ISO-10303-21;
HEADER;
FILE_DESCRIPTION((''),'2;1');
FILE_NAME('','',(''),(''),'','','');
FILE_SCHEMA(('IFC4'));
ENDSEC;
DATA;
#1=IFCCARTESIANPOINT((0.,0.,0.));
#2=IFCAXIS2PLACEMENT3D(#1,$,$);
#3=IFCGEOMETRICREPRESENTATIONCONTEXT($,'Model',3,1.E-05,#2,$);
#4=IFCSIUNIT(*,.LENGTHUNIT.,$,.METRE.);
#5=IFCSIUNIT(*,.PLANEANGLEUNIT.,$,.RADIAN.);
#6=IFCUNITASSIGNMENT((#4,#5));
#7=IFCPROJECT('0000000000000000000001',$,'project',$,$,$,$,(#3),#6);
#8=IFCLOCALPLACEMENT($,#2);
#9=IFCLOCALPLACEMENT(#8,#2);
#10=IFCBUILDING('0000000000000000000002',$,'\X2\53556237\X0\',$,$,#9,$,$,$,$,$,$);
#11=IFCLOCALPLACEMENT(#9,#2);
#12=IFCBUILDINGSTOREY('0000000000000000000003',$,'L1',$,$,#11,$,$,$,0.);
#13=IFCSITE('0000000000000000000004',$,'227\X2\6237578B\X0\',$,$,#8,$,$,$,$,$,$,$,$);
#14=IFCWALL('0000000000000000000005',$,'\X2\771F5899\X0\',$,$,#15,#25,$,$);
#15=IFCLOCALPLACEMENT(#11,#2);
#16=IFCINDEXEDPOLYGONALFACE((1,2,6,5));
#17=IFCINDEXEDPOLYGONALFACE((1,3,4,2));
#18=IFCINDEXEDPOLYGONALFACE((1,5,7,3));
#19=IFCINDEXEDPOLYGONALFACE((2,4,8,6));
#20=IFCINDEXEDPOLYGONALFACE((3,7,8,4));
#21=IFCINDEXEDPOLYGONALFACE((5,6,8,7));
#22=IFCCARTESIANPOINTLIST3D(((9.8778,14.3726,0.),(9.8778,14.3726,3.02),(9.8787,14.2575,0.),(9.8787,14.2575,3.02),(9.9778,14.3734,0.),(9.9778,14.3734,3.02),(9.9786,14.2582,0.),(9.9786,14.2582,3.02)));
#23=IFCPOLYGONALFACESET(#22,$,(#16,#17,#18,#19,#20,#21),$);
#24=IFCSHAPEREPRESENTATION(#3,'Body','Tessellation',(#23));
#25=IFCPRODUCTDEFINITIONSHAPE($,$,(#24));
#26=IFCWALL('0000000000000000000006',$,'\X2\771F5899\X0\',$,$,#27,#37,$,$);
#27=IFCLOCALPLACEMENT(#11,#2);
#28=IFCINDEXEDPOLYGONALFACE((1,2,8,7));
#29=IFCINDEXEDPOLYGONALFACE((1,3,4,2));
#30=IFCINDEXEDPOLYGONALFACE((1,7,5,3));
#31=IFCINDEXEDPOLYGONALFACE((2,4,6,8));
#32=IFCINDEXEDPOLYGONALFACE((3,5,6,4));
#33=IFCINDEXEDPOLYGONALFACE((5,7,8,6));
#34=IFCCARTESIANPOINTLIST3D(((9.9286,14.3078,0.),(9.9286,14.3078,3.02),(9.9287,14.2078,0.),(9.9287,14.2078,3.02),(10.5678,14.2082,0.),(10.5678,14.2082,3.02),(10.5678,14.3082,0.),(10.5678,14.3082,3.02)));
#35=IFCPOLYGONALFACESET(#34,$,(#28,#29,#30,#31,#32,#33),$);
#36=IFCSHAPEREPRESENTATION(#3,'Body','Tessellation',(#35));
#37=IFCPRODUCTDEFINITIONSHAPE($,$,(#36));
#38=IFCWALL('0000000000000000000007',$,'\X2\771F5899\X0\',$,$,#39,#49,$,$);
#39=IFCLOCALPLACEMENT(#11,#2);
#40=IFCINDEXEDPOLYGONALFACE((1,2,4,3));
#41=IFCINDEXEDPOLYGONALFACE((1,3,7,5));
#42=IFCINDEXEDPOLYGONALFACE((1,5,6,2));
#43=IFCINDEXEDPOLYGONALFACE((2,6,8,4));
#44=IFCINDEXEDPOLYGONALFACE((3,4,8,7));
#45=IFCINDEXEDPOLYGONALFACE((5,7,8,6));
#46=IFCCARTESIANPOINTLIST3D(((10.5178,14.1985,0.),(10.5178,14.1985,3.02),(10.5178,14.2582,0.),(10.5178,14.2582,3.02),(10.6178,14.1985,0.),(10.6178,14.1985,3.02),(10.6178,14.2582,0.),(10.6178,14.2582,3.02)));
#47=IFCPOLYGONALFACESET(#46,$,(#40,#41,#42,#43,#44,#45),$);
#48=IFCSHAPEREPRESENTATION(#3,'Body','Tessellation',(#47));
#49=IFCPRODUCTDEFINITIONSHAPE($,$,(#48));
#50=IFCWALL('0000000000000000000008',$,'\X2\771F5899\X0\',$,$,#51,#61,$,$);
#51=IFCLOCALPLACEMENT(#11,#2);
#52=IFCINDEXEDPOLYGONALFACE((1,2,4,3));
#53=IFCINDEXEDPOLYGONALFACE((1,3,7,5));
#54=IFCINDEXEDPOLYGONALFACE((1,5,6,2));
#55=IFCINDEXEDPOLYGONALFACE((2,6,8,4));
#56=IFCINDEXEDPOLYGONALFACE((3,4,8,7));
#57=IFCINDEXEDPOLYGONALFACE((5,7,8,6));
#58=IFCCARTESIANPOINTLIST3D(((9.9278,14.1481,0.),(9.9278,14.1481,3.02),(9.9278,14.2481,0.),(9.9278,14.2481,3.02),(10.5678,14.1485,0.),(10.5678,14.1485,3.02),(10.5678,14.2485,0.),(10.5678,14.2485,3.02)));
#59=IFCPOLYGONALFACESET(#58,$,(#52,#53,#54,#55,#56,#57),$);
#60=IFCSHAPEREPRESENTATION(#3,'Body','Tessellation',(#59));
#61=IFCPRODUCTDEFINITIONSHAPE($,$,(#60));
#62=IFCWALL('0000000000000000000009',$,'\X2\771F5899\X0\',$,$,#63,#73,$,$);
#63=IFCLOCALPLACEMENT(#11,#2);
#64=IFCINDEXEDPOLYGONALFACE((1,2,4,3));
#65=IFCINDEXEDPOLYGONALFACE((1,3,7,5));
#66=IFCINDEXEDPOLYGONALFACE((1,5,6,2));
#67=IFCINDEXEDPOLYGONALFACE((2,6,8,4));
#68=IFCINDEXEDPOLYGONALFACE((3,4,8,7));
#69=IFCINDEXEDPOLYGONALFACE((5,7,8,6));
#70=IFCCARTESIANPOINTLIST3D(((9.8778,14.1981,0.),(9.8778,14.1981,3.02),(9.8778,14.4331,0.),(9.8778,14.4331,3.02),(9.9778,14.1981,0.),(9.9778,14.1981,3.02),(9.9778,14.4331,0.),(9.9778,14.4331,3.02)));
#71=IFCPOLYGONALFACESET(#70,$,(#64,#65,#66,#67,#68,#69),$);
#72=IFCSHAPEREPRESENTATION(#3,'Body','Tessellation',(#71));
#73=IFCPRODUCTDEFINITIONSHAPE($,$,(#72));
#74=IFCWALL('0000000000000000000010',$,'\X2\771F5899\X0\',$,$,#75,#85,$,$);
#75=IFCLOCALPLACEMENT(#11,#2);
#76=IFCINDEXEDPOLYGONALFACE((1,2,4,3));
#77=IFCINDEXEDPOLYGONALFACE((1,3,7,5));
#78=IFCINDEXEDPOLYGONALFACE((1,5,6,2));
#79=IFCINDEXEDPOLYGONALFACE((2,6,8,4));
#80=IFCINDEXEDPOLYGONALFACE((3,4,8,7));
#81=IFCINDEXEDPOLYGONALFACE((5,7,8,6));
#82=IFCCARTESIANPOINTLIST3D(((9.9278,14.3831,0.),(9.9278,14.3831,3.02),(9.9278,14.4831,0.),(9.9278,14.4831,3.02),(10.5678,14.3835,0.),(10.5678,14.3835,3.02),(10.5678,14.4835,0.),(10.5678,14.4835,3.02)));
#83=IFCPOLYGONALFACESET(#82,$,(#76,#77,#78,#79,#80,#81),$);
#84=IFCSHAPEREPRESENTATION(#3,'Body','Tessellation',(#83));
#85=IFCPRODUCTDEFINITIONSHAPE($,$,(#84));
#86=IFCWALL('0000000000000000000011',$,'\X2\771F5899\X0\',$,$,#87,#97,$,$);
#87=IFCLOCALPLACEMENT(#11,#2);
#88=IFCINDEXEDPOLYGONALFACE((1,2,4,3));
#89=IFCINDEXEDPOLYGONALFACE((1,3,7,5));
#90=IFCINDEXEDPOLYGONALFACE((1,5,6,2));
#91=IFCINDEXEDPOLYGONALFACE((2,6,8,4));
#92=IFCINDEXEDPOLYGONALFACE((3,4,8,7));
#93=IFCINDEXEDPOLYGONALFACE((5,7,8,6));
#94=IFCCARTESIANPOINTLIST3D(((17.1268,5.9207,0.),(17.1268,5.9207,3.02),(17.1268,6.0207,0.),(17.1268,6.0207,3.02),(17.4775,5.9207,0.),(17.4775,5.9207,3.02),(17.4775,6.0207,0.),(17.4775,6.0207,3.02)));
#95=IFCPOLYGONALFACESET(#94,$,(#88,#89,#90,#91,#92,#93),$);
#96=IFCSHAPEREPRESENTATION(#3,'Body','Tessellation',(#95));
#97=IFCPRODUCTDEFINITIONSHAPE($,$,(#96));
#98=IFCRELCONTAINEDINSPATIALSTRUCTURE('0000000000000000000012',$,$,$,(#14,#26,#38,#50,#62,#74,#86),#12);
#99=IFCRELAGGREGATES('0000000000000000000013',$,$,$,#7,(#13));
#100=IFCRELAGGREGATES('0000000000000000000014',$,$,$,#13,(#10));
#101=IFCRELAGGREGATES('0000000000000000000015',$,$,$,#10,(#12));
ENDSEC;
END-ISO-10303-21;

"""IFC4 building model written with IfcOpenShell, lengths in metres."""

from ifc_helpers import new_model, si_unit, origin, place, context, project, spatial, polyline, outline, extrude, element, save


model = new_model("IFC4")

# Units and contexts
model_context = context("Model", 3, precision=1e-05, world=origin())
ifc_project = project(units=[si_unit("LENGTHUNIT", "METRE"), si_unit("PLANEANGLEUNIT", "RADIAN")], contexts=[model_context])

# Site, building, storey
site_placement = place(None, origin())
site = spatial("IfcSite", under=ifc_project, at=site_placement, Name="227户型")
building_placement = place(site_placement, origin())
building = spatial("IfcBuilding", under=site, at=building_placement, Name="单户")
storey_placement = place(building_placement, origin())
storey = spatial("IfcBuildingStorey", under=building, at=storey_placement, Name="L1", Elevation=0.0)

# Walls
wall_1_placement = place(storey_placement, origin())
element("IfcWall", 1, at=wall_1_placement, inside=storey, Name="真墙", context=model_context, shape_type="SweptSolid", body=[
    extrude(outline(polyline([(9.9778, 14.3734), (9.9786, 14.2582), (9.8787, 14.2575), (9.8778, 14.3726), (9.9778, 14.3734)])), origin(), (0.0, 0.0, 1.0), 3.02),
])
wall_2_placement = place(storey_placement, origin())
element("IfcWall", 2, at=wall_2_placement, inside=storey, Name="真墙", context=model_context, shape_type="SweptSolid", body=[
    extrude(outline(polyline([(9.9286, 14.3078), (10.5678, 14.3082), (10.5678, 14.2082), (9.9287, 14.2078), (9.9286, 14.3078)])), origin(), (0.0, 0.0, 1.0), 3.02),
])
wall_3_placement = place(storey_placement, origin())
element("IfcWall", 3, at=wall_3_placement, inside=storey, Name="真墙", context=model_context, shape_type="SweptSolid", body=[
    extrude(outline(polyline([(10.6178, 14.2582), (10.6178, 14.1985), (10.5178, 14.1985), (10.5178, 14.2582), (10.6178, 14.2582)])), origin(), (0.0, 0.0, 1.0), 3.02),
])
wall_4_placement = place(storey_placement, origin())
element("IfcWall", 4, at=wall_4_placement, inside=storey, Name="真墙", context=model_context, shape_type="SweptSolid", body=[
    extrude(outline(polyline([(10.5678, 14.1485), (9.9278, 14.1481), (9.9278, 14.2481), (10.5678, 14.2485), (10.5678, 14.1485)])), origin(), (0.0, 0.0, 1.0), 3.02),
])
wall_5_placement = place(storey_placement, origin())
element("IfcWall", 5, at=wall_5_placement, inside=storey, Name="真墙", context=model_context, shape_type="SweptSolid", body=[
    extrude(outline(polyline([(9.8778, 14.1981), (9.8778, 14.4331), (9.9778, 14.4331), (9.9778, 14.1981), (9.8778, 14.1981)])), origin(), (0.0, 0.0, 1.0), 3.02),
])
wall_6_placement = place(storey_placement, origin())
element("IfcWall", 6, at=wall_6_placement, inside=storey, Name="真墙", context=model_context, shape_type="SweptSolid", body=[
    extrude(outline(polyline([(9.9278, 14.4831), (10.5678, 14.4835), (10.5678, 14.3835), (9.9278, 14.3831), (9.9278, 14.4831)])), origin(), (0.0, 0.0, 1.0), 3.02),
])
wall_7_placement = place(storey_placement, origin())
element("IfcWall", 7, at=wall_7_placement, inside=storey, Name="真墙", context=model_context, shape_type="SweptSolid", body=[
    extrude(outline(polyline([(17.1268, 6.0207), (17.4775, 6.0207), (17.4775, 5.9207), (17.1268, 5.9207), (17.1268, 6.0207)])), origin(), (0.0, 0.0, 1.0), 3.02),
])

save(model, "model.ifc")
